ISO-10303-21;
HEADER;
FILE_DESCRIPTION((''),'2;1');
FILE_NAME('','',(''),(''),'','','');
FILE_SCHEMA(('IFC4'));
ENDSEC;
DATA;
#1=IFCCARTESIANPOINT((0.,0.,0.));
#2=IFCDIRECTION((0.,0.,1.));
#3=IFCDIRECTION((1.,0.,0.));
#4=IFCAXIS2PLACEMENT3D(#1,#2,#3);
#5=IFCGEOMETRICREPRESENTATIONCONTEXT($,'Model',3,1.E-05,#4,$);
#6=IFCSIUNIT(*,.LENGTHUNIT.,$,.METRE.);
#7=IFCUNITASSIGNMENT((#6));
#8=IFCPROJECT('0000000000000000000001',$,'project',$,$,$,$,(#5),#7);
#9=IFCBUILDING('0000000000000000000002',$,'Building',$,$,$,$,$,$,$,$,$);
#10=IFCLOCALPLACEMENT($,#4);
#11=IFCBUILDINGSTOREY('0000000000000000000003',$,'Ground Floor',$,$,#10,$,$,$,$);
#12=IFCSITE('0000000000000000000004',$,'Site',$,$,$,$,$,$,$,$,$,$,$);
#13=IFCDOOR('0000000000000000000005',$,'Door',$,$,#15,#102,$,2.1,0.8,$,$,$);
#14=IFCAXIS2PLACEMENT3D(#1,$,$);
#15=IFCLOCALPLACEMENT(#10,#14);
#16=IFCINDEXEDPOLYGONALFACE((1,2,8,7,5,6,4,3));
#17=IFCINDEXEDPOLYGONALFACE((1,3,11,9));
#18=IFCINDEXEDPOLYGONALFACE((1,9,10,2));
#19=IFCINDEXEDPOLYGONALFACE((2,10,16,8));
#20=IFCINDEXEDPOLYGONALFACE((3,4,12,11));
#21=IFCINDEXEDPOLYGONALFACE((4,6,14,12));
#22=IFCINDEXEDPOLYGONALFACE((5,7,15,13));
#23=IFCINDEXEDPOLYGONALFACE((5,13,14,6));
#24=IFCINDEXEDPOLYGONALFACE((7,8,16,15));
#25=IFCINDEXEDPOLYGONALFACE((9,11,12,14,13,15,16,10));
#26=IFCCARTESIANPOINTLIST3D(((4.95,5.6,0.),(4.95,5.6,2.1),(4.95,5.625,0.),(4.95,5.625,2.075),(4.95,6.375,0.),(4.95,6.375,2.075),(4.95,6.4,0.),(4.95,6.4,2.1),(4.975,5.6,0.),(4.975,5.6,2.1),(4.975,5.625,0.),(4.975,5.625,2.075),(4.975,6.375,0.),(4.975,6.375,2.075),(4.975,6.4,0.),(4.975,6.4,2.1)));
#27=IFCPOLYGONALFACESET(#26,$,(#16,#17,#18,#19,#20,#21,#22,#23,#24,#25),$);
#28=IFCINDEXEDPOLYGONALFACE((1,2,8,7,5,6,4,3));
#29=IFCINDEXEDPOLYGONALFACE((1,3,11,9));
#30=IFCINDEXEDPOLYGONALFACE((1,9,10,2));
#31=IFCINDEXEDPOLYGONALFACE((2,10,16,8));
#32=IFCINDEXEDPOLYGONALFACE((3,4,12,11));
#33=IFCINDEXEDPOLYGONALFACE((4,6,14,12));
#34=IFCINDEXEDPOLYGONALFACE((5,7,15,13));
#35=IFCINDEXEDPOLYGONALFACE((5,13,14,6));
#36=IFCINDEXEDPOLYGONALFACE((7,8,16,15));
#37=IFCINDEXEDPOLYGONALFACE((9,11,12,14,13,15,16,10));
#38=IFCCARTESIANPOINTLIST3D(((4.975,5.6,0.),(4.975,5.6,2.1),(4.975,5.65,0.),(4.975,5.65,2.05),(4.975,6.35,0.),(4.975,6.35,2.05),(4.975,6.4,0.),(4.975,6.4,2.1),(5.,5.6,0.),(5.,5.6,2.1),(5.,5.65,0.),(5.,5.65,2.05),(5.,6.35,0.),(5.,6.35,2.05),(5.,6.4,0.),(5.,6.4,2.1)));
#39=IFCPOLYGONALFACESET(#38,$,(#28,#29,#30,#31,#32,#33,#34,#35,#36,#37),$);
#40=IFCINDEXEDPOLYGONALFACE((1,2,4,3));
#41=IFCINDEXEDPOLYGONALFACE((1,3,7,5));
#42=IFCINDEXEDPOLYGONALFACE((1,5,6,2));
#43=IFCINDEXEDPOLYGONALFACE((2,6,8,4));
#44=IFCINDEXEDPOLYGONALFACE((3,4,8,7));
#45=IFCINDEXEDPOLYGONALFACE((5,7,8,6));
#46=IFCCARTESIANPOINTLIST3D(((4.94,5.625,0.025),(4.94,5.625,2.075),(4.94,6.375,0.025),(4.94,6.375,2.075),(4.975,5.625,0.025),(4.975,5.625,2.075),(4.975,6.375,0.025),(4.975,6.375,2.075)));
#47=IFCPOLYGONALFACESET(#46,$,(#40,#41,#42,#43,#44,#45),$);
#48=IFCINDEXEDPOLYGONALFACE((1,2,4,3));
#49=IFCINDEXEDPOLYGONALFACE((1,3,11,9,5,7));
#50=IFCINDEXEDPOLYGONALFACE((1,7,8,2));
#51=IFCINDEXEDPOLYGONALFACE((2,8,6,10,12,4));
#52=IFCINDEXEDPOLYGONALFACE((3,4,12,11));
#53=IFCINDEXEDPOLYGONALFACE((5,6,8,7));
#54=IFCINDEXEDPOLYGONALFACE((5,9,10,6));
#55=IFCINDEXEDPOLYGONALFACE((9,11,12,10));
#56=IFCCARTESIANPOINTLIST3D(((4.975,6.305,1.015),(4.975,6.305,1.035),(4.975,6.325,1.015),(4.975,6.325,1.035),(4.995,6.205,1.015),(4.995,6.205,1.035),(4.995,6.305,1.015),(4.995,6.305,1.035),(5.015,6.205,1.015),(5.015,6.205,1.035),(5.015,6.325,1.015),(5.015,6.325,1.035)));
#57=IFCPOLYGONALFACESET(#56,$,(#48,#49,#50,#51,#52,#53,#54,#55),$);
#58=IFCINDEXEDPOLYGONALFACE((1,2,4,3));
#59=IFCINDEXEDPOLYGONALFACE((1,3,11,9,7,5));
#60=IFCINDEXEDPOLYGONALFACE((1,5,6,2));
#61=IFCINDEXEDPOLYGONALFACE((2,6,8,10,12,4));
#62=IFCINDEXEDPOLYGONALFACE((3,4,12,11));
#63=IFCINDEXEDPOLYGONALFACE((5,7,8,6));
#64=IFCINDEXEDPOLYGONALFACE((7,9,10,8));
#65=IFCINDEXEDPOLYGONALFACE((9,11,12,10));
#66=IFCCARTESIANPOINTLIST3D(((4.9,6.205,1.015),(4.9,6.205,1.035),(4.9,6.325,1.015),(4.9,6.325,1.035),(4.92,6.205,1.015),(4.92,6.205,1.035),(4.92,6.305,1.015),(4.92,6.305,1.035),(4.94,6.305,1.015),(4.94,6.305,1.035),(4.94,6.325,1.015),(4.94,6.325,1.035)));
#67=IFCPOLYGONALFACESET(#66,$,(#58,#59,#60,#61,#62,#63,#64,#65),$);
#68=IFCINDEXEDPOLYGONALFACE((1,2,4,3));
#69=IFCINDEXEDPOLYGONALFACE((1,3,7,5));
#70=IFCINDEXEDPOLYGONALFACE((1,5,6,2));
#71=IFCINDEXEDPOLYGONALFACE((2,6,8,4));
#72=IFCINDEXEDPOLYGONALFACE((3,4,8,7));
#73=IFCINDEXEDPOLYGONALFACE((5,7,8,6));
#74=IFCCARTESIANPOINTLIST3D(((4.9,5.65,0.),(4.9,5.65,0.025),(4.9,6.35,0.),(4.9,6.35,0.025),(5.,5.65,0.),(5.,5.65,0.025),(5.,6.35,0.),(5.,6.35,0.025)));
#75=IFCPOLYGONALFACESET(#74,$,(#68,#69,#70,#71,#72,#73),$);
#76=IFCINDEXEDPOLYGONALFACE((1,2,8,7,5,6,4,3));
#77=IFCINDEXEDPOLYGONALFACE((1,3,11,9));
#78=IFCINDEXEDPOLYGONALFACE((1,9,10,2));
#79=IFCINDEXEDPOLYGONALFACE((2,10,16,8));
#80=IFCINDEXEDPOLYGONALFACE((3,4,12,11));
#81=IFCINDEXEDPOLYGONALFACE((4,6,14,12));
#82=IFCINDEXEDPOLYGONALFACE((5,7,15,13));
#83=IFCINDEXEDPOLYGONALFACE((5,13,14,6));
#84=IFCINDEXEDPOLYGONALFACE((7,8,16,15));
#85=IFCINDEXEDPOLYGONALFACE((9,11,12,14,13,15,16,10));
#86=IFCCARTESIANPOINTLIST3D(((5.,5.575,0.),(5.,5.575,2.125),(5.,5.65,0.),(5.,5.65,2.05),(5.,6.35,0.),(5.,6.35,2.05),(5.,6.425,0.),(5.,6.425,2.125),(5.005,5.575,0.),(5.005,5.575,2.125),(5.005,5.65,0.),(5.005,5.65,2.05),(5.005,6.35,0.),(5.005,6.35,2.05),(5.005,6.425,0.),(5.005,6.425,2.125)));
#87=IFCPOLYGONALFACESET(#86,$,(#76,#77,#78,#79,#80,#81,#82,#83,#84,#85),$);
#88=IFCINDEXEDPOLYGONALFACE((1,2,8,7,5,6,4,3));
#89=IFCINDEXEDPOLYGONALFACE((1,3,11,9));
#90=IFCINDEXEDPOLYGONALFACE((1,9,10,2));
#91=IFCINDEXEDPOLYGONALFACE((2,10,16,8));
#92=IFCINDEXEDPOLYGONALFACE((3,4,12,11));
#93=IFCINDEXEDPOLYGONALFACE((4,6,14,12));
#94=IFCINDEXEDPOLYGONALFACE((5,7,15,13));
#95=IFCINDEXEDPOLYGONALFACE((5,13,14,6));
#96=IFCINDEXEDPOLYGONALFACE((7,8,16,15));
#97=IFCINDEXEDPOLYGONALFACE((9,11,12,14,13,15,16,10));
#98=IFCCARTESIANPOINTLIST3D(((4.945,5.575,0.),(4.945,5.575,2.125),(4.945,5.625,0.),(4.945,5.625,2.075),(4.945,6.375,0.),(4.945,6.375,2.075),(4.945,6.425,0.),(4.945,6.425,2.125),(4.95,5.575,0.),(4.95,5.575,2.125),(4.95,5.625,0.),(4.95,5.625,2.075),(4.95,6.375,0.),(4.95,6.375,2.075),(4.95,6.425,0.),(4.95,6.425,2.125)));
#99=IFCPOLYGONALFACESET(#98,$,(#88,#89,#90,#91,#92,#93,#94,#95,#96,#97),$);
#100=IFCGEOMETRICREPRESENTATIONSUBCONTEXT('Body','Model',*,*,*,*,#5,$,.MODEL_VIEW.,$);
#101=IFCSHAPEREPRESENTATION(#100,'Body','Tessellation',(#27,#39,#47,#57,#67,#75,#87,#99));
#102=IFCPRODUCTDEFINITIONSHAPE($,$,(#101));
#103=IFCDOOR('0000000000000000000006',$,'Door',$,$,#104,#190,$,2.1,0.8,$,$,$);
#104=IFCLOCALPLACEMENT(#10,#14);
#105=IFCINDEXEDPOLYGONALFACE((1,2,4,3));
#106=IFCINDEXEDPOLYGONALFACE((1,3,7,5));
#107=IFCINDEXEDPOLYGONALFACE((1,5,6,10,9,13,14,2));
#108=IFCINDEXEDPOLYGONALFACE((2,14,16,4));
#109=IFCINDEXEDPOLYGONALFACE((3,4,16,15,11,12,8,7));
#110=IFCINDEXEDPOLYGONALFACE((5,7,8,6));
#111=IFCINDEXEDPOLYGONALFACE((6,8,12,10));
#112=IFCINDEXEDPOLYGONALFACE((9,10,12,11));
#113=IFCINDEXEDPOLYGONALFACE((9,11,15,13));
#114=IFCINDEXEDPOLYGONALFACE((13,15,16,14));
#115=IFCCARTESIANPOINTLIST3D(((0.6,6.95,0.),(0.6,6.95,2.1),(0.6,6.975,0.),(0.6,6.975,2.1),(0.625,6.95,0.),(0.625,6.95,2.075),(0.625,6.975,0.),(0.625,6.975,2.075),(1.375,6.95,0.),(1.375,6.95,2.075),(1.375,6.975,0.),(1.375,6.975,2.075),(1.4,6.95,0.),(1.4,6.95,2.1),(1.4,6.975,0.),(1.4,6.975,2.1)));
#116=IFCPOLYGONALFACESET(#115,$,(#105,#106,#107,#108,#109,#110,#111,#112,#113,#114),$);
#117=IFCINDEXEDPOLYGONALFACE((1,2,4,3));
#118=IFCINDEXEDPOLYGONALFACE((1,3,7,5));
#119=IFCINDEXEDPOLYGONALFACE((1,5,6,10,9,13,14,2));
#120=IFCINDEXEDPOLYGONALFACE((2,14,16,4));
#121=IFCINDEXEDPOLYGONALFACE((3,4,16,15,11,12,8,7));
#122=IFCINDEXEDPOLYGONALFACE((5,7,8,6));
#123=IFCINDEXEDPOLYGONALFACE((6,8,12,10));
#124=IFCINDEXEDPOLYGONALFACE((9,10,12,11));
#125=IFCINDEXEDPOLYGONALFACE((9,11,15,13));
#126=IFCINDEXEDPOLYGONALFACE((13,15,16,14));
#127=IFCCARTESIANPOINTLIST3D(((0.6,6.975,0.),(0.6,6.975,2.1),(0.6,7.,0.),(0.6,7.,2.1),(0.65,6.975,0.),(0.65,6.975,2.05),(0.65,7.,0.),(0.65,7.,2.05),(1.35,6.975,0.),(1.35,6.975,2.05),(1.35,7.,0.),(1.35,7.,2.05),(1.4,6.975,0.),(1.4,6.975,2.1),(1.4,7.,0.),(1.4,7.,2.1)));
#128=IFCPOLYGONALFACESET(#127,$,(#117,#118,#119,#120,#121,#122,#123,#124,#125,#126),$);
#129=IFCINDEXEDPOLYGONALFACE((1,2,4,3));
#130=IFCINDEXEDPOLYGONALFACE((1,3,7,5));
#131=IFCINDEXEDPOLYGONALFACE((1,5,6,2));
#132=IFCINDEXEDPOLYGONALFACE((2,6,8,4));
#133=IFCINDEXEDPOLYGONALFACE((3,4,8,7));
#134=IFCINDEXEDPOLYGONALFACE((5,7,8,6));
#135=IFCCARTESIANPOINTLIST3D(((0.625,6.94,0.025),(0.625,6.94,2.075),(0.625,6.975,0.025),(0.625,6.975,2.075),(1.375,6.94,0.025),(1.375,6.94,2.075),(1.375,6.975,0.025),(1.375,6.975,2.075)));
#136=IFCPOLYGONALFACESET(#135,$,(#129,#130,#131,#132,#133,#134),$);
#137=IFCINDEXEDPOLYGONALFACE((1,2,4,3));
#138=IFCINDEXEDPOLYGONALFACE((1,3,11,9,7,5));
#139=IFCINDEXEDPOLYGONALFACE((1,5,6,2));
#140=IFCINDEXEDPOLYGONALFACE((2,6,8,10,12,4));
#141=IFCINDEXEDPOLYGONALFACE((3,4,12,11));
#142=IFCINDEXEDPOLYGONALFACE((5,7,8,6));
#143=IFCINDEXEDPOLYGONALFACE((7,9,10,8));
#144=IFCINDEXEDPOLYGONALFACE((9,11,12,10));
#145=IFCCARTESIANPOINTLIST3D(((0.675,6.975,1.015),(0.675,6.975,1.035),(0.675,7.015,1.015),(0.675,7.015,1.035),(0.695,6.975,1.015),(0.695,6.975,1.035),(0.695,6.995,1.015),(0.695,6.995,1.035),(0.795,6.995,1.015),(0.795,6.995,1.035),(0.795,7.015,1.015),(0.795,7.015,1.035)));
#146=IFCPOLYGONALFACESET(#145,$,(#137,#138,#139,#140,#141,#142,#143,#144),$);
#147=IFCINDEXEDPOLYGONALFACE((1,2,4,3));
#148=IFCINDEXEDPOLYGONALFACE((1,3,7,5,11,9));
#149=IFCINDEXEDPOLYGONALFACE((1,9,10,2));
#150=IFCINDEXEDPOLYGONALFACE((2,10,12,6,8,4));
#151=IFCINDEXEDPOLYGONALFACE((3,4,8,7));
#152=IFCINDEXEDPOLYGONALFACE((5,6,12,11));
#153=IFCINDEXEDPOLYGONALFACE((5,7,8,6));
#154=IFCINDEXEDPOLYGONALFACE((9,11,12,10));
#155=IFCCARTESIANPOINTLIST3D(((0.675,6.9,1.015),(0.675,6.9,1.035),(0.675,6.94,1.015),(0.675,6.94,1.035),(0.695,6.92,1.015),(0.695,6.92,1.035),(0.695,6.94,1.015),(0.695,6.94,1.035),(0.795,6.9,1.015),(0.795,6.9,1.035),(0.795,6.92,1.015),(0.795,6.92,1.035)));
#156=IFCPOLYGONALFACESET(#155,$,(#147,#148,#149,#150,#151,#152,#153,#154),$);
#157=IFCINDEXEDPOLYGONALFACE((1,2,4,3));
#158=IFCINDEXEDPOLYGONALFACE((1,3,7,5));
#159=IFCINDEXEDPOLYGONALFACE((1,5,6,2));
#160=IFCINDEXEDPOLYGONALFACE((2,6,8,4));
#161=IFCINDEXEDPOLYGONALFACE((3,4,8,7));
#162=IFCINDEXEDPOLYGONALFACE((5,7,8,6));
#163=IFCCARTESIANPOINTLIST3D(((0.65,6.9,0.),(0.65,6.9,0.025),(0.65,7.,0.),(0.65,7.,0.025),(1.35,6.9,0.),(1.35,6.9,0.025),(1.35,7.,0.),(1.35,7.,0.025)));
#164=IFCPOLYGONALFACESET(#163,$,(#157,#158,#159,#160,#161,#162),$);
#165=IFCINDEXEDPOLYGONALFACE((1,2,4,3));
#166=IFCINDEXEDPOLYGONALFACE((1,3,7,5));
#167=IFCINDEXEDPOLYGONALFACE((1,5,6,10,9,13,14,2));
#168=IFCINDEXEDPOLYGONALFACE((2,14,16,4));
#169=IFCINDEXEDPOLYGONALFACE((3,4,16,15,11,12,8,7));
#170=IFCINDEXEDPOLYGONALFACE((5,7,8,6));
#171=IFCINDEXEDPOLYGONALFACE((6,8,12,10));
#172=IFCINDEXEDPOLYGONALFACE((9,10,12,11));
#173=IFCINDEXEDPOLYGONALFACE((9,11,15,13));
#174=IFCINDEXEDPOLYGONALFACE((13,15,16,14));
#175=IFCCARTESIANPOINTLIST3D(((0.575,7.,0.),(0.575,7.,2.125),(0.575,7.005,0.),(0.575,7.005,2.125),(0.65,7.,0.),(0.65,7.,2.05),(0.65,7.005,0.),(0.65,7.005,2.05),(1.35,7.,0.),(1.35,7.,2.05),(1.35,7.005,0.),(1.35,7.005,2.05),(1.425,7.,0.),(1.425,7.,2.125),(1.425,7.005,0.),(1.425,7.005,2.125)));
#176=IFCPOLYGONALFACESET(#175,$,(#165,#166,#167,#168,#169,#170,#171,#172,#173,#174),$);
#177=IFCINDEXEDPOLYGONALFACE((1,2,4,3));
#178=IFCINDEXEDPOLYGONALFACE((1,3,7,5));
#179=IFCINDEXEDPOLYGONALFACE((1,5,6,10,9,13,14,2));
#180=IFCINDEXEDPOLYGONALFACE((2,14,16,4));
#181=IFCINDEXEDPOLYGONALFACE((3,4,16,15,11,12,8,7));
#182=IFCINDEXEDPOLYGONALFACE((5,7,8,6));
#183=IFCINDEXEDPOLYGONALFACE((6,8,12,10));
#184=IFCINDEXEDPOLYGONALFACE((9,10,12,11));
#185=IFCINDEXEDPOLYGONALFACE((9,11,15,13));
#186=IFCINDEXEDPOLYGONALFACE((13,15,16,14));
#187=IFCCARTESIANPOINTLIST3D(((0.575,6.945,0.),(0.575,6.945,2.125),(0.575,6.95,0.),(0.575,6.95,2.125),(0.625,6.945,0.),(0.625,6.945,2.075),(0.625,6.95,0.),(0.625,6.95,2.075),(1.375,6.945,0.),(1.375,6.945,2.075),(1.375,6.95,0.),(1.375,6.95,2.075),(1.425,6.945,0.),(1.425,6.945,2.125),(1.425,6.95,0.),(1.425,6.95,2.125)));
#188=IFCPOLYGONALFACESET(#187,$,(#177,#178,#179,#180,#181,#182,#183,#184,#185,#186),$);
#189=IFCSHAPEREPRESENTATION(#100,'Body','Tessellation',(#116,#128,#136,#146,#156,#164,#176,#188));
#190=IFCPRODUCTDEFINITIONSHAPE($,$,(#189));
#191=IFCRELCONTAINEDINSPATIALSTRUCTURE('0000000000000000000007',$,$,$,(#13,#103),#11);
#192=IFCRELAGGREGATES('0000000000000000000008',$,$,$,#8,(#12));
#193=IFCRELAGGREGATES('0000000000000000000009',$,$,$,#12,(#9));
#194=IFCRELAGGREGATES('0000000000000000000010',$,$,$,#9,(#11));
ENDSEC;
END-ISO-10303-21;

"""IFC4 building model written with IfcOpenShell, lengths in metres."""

from ifc_helpers import new_model, si_unit, frame, origin_with_axes, place, context, subcontext, project, spatial, line, indexed_curve, outline, extrude, element, save


model = new_model("IFC4")

# Units and contexts
model_context = context("Model", 3, precision=1e-05, world=origin_with_axes())
body_context = subcontext(model_context, "Body", "Model", "MODEL_VIEW")
ifc_project = project(units=[si_unit("LENGTHUNIT", "METRE")], contexts=[model_context])

# Site, building, storey
site = spatial("IfcSite", under=ifc_project, Name="Site")
building = spatial("IfcBuilding", under=site, Name="Building")
storey_placement = place(None, origin_with_axes())
storey = spatial("IfcBuildingStorey", under=building, at=storey_placement, Name="Ground Floor")

# Doors
door_1_placement = place(storey_placement, frame((5.0, 5.6, 0.0), z_axis=(0.0, 0.0, 1.0), x_axis=(0.0, 1.0, 0.0)))
element("IfcDoor", 1, at=door_1_placement, inside=storey, Name="Door", OverallHeight=2.1, OverallWidth=0.8, context=body_context, shape_type="SweptSolid", body=[
    extrude(outline(indexed_curve([(0.0, 0.0), (0.0, 2.1), (0.8, 2.1), (0.8, 0.0), (0.775, 0.0), (0.775, 2.075), (0.025, 2.075), (0.025, 0.0)], segments=[line(1, 2, 3, 4, 5, 6, 7, 8, 1)])), frame((0.0, 0.025, 0.0), z_axis=(0.0, -1.0, 0.0), x_axis=(1.0, 0.0, 0.0)), (0.0, 0.0, -1.0), 0.025),
    extrude(outline(indexed_curve([(0.0, 0.0), (0.0, 2.1), (0.8, 2.1), (0.8, 0.0), (0.75, 0.0), (0.75, 2.05), (0.05, 2.05), (0.05, 0.0)], segments=[line(1, 2, 3, 4, 5, 6, 7, 8, 1)])), frame((0.0, 0.0, 0.0), z_axis=(0.0, -1.0, 0.0), x_axis=(1.0, 0.0, 0.0)), (0.0, 0.0, -1.0), 0.025),
    extrude(outline(indexed_curve([(0.0, 0.0), (0.75, 0.0), (0.75, 0.035), (0.0, 0.035)], segments=[line(1, 2, 3, 4, 1)])), frame((0.025, 0.025, 0.025), z_axis=(0.0, 0.0, 1.0), x_axis=(1.0, 0.0, 0.0)), (0.0, 0.0, 1.0), 2.05),
    extrude(outline(indexed_curve([(0.0, 0.0), (0.0, -0.04), (-0.12, -0.04), (-0.12, -0.02), (-0.02, -0.02), (-0.02, 0.0)], segments=[line(1, 2, 3, 4, 5, 6, 1)])), frame((0.725, 0.025, 1.015), z_axis=(0.0, 0.0, 1.0), x_axis=(1.0, 0.0, 0.0)), (0.0, 0.0, 1.0), 0.02),
    extrude(outline(indexed_curve([(0.0, 0.0), (0.0, 0.04), (-0.12, 0.04), (-0.12, 0.02), (-0.02, 0.02), (-0.02, 0.0)], segments=[line(1, 2, 3, 4, 5, 6, 1)])), frame((0.725, 0.06, 1.015), z_axis=(0.0, 0.0, 1.0), x_axis=(1.0, 0.0, 0.0)), (0.0, 0.0, 1.0), 0.02),
    extrude(outline(indexed_curve([(0.0, 0.0), (0.7, 0.0), (0.7, 0.1), (0.0, 0.1)], segments=[line(1, 2, 3, 4, 1)])), frame((0.05, 0.0, 0.0), z_axis=(0.0, 0.0, 1.0), x_axis=(1.0, 0.0, 0.0)), (0.0, 0.0, 1.0), 0.025),
    extrude(outline(indexed_curve([(0.0, 0.0), (0.0, 2.125), (0.85, 2.125), (0.85, 0.0), (0.775, 0.0), (0.775, 2.05), (0.075, 2.05), (0.075, 0.0)], segments=[line(1, 2, 3, 4, 5, 6, 7, 8, 1)])), frame((-0.025, -0.005, 0.0), z_axis=(0.0, -1.0, 0.0), x_axis=(1.0, 0.0, 0.0)), (0.0, 0.0, -1.0), 0.005),
    extrude(outline(indexed_curve([(0.0, 0.0), (0.0, 2.125), (0.85, 2.125), (0.85, 0.0), (0.8, 0.0), (0.8, 2.075), (0.05, 2.075), (0.05, 0.0)], segments=[line(1, 2, 3, 4, 5, 6, 7, 8, 1)])), frame((-0.025, 0.05, 0.0), z_axis=(0.0, -1.0, 0.0), x_axis=(1.0, 0.0, 0.0)), (0.0, 0.0, -1.0), 0.005),
])
door_2_placement = place(storey_placement, frame((1.4, 7.0, 0.0), z_axis=(0.0, 0.0, 1.0), x_axis=(-1.0, 0.0, 0.0)))
element("IfcDoor", 2, at=door_2_placement, inside=storey, Name="Door", OverallHeight=2.1, OverallWidth=0.8, context=body_context, shape_type="SweptSolid", body=[
    extrude(outline(indexed_curve([(0.0, 0.0), (0.0, 2.1), (0.8, 2.1), (0.8, 0.0), (0.775, 0.0), (0.775, 2.075), (0.025, 2.075), (0.025, 0.0)], segments=[line(1, 2, 3, 4, 5, 6, 7, 8, 1)])), frame((0.0, 0.025, 0.0), z_axis=(0.0, -1.0, 0.0), x_axis=(1.0, 0.0, 0.0)), (0.0, 0.0, -1.0), 0.025),
    extrude(outline(indexed_curve([(0.0, 0.0), (0.0, 2.1), (0.8, 2.1), (0.8, 0.0), (0.75, 0.0), (0.75, 2.05), (0.05, 2.05), (0.05, 0.0)], segments=[line(1, 2, 3, 4, 5, 6, 7, 8, 1)])), frame((0.0, 0.0, 0.0), z_axis=(0.0, -1.0, 0.0), x_axis=(1.0, 0.0, 0.0)), (0.0, 0.0, -1.0), 0.025),
    extrude(outline(indexed_curve([(0.0, 0.0), (0.75, 0.0), (0.75, 0.035), (0.0, 0.035)], segments=[line(1, 2, 3, 4, 1)])), frame((0.025, 0.025, 0.025), z_axis=(0.0, 0.0, 1.0), x_axis=(1.0, 0.0, 0.0)), (0.0, 0.0, 1.0), 2.05),
    extrude(outline(indexed_curve([(0.0, 0.0), (0.0, -0.04), (-0.12, -0.04), (-0.12, -0.02), (-0.02, -0.02), (-0.02, 0.0)], segments=[line(1, 2, 3, 4, 5, 6, 1)])), frame((0.725, 0.025, 1.015), z_axis=(0.0, 0.0, 1.0), x_axis=(1.0, 0.0, 0.0)), (0.0, 0.0, 1.0), 0.02),
    extrude(outline(indexed_curve([(0.0, 0.0), (0.0, 0.04), (-0.12, 0.04), (-0.12, 0.02), (-0.02, 0.02), (-0.02, 0.0)], segments=[line(1, 2, 3, 4, 5, 6, 1)])), frame((0.725, 0.06, 1.015), z_axis=(0.0, 0.0, 1.0), x_axis=(1.0, 0.0, 0.0)), (0.0, 0.0, 1.0), 0.02),
    extrude(outline(indexed_curve([(0.0, 0.0), (0.7, 0.0), (0.7, 0.1), (0.0, 0.1)], segments=[line(1, 2, 3, 4, 1)])), frame((0.05, 0.0, 0.0), z_axis=(0.0, 0.0, 1.0), x_axis=(1.0, 0.0, 0.0)), (0.0, 0.0, 1.0), 0.025),
    extrude(outline(indexed_curve([(0.0, 0.0), (0.0, 2.125), (0.85, 2.125), (0.85, 0.0), (0.775, 0.0), (0.775, 2.05), (0.075, 2.05), (0.075, 0.0)], segments=[line(1, 2, 3, 4, 5, 6, 7, 8, 1)])), frame((-0.025, -0.005, 0.0), z_axis=(0.0, -1.0, 0.0), x_axis=(1.0, 0.0, 0.0)), (0.0, 0.0, -1.0), 0.005),
    extrude(outline(indexed_curve([(0.0, 0.0), (0.0, 2.125), (0.85, 2.125), (0.85, 0.0), (0.8, 0.0), (0.8, 2.075), (0.05, 2.075), (0.05, 0.0)], segments=[line(1, 2, 3, 4, 5, 6, 7, 8, 1)])), frame((-0.025, 0.05, 0.0), z_axis=(0.0, -1.0, 0.0), x_axis=(1.0, 0.0, 0.0)), (0.0, 0.0, -1.0), 0.005),
])

save(model, "model.ifc")
